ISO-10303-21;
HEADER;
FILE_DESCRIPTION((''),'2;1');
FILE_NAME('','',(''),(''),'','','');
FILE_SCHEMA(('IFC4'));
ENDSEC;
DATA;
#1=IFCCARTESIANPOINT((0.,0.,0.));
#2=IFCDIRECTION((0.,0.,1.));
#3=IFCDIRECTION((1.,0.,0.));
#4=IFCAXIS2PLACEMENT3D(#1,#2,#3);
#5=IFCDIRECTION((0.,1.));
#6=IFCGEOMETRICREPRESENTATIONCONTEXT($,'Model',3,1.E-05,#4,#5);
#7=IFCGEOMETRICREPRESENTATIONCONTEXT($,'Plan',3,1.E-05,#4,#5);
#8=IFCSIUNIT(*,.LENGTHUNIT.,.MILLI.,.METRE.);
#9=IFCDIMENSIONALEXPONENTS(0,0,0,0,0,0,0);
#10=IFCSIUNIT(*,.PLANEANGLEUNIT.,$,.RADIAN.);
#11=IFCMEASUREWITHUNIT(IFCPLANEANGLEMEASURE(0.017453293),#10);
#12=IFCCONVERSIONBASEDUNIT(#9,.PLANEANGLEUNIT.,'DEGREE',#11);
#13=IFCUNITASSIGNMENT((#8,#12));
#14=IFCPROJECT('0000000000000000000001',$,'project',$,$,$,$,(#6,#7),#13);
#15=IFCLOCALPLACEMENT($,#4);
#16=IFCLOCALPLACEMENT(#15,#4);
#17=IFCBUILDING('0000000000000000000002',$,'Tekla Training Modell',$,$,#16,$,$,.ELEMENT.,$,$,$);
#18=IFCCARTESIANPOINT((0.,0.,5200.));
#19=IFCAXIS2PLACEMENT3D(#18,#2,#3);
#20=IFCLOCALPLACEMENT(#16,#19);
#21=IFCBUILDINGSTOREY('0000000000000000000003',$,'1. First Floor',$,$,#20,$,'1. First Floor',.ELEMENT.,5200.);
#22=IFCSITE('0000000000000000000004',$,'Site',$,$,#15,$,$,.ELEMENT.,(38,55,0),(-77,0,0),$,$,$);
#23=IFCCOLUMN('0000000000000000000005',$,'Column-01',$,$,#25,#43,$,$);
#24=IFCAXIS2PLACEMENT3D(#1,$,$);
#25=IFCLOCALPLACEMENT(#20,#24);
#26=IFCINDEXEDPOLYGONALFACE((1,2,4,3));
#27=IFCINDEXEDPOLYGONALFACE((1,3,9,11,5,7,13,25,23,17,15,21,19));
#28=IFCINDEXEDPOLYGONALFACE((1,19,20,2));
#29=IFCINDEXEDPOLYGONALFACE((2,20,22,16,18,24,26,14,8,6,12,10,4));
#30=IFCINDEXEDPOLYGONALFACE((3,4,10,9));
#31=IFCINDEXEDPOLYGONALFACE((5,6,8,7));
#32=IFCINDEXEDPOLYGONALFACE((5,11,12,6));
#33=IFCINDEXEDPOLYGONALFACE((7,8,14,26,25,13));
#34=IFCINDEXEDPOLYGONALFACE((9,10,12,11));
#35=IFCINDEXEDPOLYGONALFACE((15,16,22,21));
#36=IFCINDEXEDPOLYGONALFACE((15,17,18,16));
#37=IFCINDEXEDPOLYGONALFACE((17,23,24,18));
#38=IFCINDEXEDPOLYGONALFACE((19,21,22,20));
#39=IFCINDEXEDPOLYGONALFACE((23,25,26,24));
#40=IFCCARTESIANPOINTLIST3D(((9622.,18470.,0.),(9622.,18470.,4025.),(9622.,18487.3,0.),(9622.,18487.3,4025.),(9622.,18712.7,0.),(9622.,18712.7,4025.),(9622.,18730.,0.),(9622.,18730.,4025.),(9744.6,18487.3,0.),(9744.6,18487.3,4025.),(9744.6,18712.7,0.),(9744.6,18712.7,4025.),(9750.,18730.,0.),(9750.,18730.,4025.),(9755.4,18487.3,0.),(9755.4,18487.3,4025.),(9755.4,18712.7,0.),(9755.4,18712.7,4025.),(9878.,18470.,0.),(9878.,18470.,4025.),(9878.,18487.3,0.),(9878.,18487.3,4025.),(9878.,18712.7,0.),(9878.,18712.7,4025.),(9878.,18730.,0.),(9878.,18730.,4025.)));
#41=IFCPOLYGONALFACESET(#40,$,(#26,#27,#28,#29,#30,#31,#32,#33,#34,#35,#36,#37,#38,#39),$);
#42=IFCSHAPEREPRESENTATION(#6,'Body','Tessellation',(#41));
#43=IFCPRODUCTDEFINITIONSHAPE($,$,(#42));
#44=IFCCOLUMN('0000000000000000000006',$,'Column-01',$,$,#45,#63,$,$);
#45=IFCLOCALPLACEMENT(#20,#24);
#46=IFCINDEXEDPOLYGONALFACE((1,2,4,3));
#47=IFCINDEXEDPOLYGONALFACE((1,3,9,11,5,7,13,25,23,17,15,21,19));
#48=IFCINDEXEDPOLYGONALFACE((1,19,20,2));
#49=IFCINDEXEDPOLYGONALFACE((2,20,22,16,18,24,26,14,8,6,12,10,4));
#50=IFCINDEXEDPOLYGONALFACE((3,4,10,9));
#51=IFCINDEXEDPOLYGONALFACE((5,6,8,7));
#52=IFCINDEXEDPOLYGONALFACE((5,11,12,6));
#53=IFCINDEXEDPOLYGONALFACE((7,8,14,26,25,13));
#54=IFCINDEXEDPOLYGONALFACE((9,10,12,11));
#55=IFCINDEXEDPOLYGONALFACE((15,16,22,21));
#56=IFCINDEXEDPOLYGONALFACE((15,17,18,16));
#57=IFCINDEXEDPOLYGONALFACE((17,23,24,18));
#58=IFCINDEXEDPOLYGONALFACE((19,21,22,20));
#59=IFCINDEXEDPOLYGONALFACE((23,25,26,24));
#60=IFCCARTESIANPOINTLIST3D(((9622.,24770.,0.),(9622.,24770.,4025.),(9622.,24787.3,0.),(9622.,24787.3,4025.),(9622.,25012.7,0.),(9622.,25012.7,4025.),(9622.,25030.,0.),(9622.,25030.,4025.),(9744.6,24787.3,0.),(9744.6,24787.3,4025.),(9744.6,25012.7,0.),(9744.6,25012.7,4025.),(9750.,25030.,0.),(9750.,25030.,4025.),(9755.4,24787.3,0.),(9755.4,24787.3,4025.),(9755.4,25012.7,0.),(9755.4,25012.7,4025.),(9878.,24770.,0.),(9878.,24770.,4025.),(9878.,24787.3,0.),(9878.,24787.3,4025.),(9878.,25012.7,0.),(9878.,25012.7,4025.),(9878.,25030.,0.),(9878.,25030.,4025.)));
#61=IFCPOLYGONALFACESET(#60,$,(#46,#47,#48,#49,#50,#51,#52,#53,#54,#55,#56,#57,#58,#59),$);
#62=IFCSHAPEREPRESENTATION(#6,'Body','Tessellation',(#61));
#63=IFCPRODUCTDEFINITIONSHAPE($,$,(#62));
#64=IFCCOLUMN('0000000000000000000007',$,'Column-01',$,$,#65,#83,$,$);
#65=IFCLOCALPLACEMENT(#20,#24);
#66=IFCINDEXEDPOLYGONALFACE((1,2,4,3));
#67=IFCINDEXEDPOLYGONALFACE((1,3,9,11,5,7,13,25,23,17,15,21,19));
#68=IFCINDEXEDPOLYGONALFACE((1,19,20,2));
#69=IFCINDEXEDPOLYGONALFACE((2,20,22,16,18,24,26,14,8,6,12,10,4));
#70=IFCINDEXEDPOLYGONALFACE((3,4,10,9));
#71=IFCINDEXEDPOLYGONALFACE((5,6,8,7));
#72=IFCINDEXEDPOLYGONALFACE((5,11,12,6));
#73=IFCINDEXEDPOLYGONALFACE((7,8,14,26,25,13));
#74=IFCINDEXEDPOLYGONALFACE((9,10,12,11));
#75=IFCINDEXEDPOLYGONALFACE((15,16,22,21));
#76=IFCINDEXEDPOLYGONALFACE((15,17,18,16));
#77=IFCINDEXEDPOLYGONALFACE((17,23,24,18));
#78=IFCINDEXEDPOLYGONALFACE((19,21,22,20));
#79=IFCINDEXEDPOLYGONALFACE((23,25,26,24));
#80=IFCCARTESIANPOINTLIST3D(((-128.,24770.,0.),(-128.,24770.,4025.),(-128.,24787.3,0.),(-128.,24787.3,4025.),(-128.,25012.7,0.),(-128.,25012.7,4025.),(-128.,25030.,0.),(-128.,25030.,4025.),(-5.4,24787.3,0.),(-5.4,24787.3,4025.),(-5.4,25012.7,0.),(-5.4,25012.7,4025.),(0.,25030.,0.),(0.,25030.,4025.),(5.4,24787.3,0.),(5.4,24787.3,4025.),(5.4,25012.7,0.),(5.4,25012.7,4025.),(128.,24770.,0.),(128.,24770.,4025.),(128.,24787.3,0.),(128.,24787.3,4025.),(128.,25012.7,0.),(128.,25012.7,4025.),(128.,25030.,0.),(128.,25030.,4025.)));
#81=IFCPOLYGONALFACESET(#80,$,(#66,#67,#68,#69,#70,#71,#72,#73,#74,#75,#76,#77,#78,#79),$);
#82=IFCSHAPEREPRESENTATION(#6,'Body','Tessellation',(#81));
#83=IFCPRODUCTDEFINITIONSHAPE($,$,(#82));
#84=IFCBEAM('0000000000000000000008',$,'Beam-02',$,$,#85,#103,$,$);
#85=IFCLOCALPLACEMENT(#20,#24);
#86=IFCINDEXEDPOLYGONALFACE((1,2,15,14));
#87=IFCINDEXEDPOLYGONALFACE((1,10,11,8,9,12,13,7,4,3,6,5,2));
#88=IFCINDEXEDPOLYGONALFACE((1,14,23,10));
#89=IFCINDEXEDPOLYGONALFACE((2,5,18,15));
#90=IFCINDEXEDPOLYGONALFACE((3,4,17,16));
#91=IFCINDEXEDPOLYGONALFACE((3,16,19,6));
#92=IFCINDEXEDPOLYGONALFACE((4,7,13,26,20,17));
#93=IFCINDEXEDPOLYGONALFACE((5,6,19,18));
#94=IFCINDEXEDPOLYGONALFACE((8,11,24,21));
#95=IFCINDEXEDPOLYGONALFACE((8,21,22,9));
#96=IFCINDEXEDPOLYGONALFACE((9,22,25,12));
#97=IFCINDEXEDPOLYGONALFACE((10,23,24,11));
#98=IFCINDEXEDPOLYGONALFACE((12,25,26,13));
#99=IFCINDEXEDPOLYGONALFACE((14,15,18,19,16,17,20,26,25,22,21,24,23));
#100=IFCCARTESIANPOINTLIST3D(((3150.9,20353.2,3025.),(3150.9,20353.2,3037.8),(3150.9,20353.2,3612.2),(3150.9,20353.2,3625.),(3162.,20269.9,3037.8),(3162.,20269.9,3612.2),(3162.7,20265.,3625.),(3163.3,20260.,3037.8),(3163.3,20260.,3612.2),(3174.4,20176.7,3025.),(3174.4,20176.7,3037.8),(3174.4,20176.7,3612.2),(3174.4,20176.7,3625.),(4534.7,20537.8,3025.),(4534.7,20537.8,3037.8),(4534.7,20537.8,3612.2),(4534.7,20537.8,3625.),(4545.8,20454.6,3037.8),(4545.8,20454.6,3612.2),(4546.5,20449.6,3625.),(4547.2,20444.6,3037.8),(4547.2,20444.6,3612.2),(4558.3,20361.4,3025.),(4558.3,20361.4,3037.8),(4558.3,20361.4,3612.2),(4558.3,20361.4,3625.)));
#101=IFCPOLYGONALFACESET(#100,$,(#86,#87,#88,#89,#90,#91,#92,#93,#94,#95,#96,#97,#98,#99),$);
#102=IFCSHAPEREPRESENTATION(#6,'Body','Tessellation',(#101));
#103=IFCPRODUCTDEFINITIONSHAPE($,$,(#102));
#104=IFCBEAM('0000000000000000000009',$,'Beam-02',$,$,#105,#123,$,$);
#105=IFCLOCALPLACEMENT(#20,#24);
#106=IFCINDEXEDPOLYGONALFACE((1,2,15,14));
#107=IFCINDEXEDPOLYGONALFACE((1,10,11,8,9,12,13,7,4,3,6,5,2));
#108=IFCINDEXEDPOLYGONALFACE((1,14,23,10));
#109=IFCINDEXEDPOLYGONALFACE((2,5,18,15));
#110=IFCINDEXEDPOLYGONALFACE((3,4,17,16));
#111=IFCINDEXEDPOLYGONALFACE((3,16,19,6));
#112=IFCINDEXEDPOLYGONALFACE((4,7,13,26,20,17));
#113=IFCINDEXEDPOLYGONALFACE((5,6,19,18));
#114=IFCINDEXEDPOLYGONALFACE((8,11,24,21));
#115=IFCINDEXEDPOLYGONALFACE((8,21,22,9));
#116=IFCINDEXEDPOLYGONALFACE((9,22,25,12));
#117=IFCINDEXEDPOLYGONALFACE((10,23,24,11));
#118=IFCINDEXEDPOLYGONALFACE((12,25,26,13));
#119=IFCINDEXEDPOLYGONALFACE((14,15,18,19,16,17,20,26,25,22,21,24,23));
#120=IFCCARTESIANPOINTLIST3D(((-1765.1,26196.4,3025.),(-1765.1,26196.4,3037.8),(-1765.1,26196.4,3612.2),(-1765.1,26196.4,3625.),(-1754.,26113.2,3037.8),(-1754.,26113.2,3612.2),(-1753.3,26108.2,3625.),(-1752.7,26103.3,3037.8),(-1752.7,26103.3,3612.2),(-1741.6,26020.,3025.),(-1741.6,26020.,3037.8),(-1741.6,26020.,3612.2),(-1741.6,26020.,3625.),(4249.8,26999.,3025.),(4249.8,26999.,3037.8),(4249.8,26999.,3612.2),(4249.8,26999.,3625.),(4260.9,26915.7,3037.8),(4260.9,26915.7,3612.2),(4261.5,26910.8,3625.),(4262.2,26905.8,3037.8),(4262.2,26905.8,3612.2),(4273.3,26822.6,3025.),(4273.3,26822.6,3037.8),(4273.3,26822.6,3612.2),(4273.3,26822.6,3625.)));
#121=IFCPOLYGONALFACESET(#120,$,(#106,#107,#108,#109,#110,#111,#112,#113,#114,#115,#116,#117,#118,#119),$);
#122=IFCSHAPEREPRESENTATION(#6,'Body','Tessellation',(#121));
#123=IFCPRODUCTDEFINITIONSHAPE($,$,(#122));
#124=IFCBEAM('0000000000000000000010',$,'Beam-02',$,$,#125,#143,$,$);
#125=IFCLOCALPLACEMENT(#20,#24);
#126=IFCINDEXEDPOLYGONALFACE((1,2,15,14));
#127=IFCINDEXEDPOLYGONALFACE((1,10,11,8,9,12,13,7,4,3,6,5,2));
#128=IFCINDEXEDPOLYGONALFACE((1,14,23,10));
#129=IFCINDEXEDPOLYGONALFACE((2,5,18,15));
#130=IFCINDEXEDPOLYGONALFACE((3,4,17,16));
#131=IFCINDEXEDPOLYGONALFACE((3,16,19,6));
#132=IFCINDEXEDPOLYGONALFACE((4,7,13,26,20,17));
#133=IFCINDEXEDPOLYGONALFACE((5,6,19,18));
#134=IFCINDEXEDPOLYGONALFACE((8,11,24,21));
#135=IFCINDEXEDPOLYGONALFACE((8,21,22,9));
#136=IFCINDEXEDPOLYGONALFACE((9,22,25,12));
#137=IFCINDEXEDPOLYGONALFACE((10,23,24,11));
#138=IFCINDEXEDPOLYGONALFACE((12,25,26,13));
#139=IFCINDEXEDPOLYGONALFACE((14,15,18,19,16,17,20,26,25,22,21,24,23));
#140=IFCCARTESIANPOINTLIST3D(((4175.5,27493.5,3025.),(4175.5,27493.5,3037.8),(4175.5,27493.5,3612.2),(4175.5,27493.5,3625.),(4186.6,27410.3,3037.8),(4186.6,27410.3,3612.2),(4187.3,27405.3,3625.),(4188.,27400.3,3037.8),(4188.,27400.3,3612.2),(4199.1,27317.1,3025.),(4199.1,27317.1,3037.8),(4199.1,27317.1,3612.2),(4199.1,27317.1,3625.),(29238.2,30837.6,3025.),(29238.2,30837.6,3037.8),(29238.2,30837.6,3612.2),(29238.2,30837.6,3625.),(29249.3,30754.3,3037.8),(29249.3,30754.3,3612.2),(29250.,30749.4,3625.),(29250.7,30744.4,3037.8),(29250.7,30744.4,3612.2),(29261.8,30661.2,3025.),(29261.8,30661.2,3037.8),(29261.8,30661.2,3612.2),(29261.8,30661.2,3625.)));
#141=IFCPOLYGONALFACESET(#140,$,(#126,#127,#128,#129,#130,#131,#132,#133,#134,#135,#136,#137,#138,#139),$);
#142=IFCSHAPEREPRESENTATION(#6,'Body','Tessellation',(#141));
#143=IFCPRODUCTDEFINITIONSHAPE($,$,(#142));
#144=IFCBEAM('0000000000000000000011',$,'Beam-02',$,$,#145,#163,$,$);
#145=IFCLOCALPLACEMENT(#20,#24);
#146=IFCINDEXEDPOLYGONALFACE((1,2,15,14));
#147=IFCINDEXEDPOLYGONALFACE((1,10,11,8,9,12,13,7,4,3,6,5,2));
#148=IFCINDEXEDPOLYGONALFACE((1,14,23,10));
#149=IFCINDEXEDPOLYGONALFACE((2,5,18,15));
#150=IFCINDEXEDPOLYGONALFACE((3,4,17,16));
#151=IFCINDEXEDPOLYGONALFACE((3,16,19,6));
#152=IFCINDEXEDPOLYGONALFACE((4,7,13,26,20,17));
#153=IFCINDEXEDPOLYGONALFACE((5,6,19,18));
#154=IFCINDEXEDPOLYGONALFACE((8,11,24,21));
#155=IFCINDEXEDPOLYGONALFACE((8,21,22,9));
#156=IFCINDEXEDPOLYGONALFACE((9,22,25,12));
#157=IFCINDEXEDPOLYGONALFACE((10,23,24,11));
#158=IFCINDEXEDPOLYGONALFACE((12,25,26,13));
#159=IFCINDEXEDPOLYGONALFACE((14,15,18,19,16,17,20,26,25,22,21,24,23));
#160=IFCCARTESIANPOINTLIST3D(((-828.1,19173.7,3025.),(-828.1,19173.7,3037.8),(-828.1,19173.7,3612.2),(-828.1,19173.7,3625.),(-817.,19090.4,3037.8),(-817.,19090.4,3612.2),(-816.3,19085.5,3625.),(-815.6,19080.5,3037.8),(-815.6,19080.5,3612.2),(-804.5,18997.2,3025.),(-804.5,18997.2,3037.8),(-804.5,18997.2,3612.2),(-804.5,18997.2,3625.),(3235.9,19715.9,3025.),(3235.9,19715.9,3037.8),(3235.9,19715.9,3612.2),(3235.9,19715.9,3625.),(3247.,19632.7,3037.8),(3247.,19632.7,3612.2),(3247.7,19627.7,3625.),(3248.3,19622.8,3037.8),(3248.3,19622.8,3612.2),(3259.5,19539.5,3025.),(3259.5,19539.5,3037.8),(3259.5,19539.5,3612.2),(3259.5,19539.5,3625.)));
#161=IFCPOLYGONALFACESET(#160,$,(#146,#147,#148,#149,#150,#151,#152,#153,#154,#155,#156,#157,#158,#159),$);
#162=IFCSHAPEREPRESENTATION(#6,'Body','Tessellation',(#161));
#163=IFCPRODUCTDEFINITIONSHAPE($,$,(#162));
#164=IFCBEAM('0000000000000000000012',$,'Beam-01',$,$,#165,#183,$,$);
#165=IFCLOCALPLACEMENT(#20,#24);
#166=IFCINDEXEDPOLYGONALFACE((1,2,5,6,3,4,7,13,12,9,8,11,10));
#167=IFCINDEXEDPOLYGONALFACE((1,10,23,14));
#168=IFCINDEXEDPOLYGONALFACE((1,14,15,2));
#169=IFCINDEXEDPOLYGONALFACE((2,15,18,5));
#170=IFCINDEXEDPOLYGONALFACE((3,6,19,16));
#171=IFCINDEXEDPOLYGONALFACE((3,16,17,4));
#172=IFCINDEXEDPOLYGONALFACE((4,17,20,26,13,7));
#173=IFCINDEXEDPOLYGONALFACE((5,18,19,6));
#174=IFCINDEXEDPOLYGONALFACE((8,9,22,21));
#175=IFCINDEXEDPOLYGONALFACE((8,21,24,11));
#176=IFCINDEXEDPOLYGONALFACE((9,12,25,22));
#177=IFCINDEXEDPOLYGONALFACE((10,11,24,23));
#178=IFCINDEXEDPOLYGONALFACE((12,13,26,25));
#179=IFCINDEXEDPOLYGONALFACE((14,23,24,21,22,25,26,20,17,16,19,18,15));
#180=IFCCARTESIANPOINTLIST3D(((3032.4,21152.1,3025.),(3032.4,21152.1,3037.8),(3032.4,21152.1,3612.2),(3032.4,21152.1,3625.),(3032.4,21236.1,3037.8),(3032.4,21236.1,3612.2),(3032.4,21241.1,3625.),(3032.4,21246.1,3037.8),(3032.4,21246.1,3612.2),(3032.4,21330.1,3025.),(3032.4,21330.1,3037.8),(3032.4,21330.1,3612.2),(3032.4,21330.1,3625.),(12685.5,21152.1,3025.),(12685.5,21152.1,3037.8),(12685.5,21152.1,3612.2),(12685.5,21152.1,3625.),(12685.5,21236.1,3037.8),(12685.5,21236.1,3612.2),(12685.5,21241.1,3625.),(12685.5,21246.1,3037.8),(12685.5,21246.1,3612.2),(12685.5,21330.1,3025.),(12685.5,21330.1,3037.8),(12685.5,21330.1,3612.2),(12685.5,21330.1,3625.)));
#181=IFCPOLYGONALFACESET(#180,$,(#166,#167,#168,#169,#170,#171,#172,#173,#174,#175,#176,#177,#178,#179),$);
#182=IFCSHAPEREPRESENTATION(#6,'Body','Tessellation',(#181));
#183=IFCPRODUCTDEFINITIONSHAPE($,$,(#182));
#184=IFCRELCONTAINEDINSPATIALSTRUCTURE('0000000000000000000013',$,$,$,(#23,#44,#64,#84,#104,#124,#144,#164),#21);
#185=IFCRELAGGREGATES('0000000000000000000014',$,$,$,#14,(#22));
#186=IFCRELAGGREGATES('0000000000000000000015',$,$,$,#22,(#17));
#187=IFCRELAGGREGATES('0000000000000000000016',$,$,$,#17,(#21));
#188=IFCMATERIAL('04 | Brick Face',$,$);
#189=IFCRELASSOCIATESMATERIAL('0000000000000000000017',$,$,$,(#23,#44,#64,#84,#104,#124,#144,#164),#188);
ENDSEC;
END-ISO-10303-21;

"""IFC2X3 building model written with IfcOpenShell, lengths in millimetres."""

from ifc_helpers import new_model, entity, si_unit, converted_unit, direction, frame, origin_with_axes, place, context, project, spatial, polyline, outline, extrude, material, element, save


model = new_model("IFC2X3")

# Units and contexts
model_context = context("Model", 3, precision=1e-05, world=origin_with_axes(), true_north=direction((0.0, 1.0)))
plan_context = context("Plan", 3, precision=1e-05, world=origin_with_axes(), true_north=direction((0.0, 1.0)))
ifc_project = project(units=[si_unit("LENGTHUNIT", "METRE", prefix="MILLI"), converted_unit("PLANEANGLEUNIT", "DEGREE", entity("IfcPlaneAngleMeasure", 0.017453293), si_unit("PLANEANGLEUNIT", "RADIAN"), dimensions=[0, 0, 0, 0, 0, 0, 0])], contexts=[model_context, plan_context])

# Site, building, storey
site_placement = place(None, origin_with_axes())
site = spatial("IfcSite", under=ifc_project, at=site_placement, Name="Site", CompositionType="ELEMENT", RefLatitude=(38, 55, 0), RefLongitude=(-77, 0, 0))
building_placement = place(site_placement, origin_with_axes())
building = spatial("IfcBuilding", under=site, at=building_placement, Name="Tekla Training Modell", CompositionType="ELEMENT")
storey_placement = place(building_placement, frame((0.0, 0.0, 5200.0), z_axis=(0.0, 0.0, 1.0), x_axis=(1.0, 0.0, 0.0)))
storey = spatial("IfcBuildingStorey", under=building, at=storey_placement, Name="1. First Floor", LongName="1. First Floor", CompositionType="ELEMENT", Elevation=5200.0)

# Columns
ifc_material_1 = material(Name="04 | Brick Face")
for number, where, z_axis, x_axis, name in (
    (1, (9750.0, 18600.0, 0.0), (0.0, 0.0, 1.0), (1.0, 0.0, 0.0), "Column-01"),
    (2, (9750.0, 24900.0, 0.0), (0.0, 0.0, 1.0), (1.0, 0.0, 0.0), "Column-01"),
    (3, (0.0, 24900.0, 0.0), (0.0, 0.0, 1.0), (1.0, 0.0, 0.0), "Column-01"),
):
    element("IfcColumn", number, at=place(storey_placement, frame(where, z_axis=z_axis, x_axis=x_axis)), inside=storey, material=ifc_material_1, Name=name, context=model_context, shape_type="SweptSolid", body=[
        extrude(outline(polyline([(0.0, 130.0), (-128.0, 130.0), (-128.0, 112.7), (-5.3, 112.7), (-5.3, -112.7), (-128.0, -112.7), (-128.0, -130.0), (128.0, -130.0), (128.0, -112.7), (5.3, -112.7), (5.3, 112.7), (128.0, 112.7), (128.0, 130.0), (0.0, 130.0)])), origin_with_axes(), (0.0, 0.0, 1.0), 4025.0),
    ])

# Beams
beam_1_placement = place(storey_placement, frame((3162.7, 20265.0, 3325.0), z_axis=(0.0, 0.0, 1.0), x_axis=(0.132256, -0.991216, 0.0)))
element("IfcBeam", 4, at=beam_1_placement, inside=storey, material=ifc_material_1, Name="Beam-02", context=model_context, shape_type="SweptSolid", body=[
    extrude(outline(polyline([(0.0, 300.0), (-89.0, 300.0), (-89.0, 287.2), (-5.0, 287.2), (-5.0, -287.2), (-89.0, -287.2), (-89.0, -300.0), (89.0, -300.0), (89.0, -287.2), (5.0, -287.2), (5.0, 287.2), (89.0, 287.2), (89.0, 300.0), (0.0, 300.0)])), frame((0.0, 1396.1, 0.0), z_axis=(0.0, -1.0, 0.0), x_axis=(1.0, 0.0, 0.0)), (0.0, 0.0, 1.0), 1396.1),
])
beam_2_placement = place(storey_placement, frame((-1753.3, 26108.2, 3325.0), z_axis=(0.0, 0.0, 1.0), x_axis=(0.132256, -0.991216, 0.0)))
element("IfcBeam", 5, at=beam_2_placement, inside=storey, material=ifc_material_1, Name="Beam-02", context=model_context, shape_type="SweptSolid", body=[
    extrude(outline(polyline([(0.0, 300.0), (-89.0, 300.0), (-89.0, 287.2), (-5.0, 287.2), (-5.0, -287.2), (-89.0, -287.2), (-89.0, -300.0), (89.0, -300.0), (89.0, -287.2), (5.0, -287.2), (5.0, 287.2), (89.0, 287.2), (89.0, 300.0), (0.0, 300.0)])), frame((0.0, 6068.2, 0.0), z_axis=(0.0, -1.0, 0.0), x_axis=(1.0, 0.0, 0.0)), (0.0, 0.0, 1.0), 6068.2),
])
beam_3_placement = place(storey_placement, frame((4187.3, 27405.3, 3325.0), z_axis=(0.0, 0.0, 1.0), x_axis=(0.132256, -0.991216, 0.0)))
element("IfcBeam", 6, at=beam_3_placement, inside=storey, material=ifc_material_1, Name="Beam-02", context=model_context, shape_type="SweptSolid", body=[
    extrude(outline(polyline([(0.0, 300.0), (-89.0, 300.0), (-89.0, 287.2), (-5.0, 287.2), (-5.0, -287.2), (-89.0, -287.2), (-89.0, -300.0), (89.0, -300.0), (89.0, -287.2), (5.0, -287.2), (5.0, 287.2), (89.0, 287.2), (89.0, 300.0), (0.0, 300.0)])), frame((0.0, 25284.8, 0.0), z_axis=(0.0, -1.0, 0.0), x_axis=(1.0, 0.0, 0.0)), (0.0, 0.0, 1.0), 25284.8),
])
beam_4_placement = place(storey_placement, frame((-816.3, 19085.5, 3325.0), z_axis=(0.0, 0.0, 1.0), x_axis=(0.132256, -0.991216, 0.0)))
element("IfcBeam", 7, at=beam_4_placement, inside=storey, material=ifc_material_1, Name="Beam-02", context=model_context, shape_type="SweptSolid", body=[
    extrude(outline(polyline([(0.0, 300.0), (-89.0, 300.0), (-89.0, 287.2), (-5.0, 287.2), (-5.0, -287.2), (-89.0, -287.2), (-89.0, -300.0), (89.0, -300.0), (89.0, -287.2), (5.0, -287.2), (5.0, 287.2), (89.0, 287.2), (89.0, 300.0), (0.0, 300.0)])), frame((0.0, 4100.0, 0.0), z_axis=(0.0, -1.0, 0.0), x_axis=(1.0, 0.0, 0.0)), (0.0, 0.0, 1.0), 4100.0),
])
beam_5_placement = place(storey_placement, frame((3032.4, 21241.1, 3325.0), z_axis=(0.0, 0.0, 1.0), x_axis=(0.0, -1.0, 0.0)))
element("IfcBeam", 8, at=beam_5_placement, inside=storey, material=ifc_material_1, Name="Beam-01", context=model_context, shape_type="SweptSolid", body=[
    extrude(outline(polyline([(0.0, 300.0), (-89.0, 300.0), (-89.0, 287.2), (-5.0, 287.2), (-5.0, -287.2), (-89.0, -287.2), (-89.0, -300.0), (89.0, -300.0), (89.0, -287.2), (5.0, -287.2), (5.0, 287.2), (89.0, 287.2), (89.0, 300.0), (0.0, 300.0)])), frame((0.0, 9653.1, 0.0), z_axis=(0.0, -1.0, 0.0), x_axis=(1.0, 0.0, 0.0)), (0.0, 0.0, 1.0), 9653.1),
])

save(model, "model.ifc")
